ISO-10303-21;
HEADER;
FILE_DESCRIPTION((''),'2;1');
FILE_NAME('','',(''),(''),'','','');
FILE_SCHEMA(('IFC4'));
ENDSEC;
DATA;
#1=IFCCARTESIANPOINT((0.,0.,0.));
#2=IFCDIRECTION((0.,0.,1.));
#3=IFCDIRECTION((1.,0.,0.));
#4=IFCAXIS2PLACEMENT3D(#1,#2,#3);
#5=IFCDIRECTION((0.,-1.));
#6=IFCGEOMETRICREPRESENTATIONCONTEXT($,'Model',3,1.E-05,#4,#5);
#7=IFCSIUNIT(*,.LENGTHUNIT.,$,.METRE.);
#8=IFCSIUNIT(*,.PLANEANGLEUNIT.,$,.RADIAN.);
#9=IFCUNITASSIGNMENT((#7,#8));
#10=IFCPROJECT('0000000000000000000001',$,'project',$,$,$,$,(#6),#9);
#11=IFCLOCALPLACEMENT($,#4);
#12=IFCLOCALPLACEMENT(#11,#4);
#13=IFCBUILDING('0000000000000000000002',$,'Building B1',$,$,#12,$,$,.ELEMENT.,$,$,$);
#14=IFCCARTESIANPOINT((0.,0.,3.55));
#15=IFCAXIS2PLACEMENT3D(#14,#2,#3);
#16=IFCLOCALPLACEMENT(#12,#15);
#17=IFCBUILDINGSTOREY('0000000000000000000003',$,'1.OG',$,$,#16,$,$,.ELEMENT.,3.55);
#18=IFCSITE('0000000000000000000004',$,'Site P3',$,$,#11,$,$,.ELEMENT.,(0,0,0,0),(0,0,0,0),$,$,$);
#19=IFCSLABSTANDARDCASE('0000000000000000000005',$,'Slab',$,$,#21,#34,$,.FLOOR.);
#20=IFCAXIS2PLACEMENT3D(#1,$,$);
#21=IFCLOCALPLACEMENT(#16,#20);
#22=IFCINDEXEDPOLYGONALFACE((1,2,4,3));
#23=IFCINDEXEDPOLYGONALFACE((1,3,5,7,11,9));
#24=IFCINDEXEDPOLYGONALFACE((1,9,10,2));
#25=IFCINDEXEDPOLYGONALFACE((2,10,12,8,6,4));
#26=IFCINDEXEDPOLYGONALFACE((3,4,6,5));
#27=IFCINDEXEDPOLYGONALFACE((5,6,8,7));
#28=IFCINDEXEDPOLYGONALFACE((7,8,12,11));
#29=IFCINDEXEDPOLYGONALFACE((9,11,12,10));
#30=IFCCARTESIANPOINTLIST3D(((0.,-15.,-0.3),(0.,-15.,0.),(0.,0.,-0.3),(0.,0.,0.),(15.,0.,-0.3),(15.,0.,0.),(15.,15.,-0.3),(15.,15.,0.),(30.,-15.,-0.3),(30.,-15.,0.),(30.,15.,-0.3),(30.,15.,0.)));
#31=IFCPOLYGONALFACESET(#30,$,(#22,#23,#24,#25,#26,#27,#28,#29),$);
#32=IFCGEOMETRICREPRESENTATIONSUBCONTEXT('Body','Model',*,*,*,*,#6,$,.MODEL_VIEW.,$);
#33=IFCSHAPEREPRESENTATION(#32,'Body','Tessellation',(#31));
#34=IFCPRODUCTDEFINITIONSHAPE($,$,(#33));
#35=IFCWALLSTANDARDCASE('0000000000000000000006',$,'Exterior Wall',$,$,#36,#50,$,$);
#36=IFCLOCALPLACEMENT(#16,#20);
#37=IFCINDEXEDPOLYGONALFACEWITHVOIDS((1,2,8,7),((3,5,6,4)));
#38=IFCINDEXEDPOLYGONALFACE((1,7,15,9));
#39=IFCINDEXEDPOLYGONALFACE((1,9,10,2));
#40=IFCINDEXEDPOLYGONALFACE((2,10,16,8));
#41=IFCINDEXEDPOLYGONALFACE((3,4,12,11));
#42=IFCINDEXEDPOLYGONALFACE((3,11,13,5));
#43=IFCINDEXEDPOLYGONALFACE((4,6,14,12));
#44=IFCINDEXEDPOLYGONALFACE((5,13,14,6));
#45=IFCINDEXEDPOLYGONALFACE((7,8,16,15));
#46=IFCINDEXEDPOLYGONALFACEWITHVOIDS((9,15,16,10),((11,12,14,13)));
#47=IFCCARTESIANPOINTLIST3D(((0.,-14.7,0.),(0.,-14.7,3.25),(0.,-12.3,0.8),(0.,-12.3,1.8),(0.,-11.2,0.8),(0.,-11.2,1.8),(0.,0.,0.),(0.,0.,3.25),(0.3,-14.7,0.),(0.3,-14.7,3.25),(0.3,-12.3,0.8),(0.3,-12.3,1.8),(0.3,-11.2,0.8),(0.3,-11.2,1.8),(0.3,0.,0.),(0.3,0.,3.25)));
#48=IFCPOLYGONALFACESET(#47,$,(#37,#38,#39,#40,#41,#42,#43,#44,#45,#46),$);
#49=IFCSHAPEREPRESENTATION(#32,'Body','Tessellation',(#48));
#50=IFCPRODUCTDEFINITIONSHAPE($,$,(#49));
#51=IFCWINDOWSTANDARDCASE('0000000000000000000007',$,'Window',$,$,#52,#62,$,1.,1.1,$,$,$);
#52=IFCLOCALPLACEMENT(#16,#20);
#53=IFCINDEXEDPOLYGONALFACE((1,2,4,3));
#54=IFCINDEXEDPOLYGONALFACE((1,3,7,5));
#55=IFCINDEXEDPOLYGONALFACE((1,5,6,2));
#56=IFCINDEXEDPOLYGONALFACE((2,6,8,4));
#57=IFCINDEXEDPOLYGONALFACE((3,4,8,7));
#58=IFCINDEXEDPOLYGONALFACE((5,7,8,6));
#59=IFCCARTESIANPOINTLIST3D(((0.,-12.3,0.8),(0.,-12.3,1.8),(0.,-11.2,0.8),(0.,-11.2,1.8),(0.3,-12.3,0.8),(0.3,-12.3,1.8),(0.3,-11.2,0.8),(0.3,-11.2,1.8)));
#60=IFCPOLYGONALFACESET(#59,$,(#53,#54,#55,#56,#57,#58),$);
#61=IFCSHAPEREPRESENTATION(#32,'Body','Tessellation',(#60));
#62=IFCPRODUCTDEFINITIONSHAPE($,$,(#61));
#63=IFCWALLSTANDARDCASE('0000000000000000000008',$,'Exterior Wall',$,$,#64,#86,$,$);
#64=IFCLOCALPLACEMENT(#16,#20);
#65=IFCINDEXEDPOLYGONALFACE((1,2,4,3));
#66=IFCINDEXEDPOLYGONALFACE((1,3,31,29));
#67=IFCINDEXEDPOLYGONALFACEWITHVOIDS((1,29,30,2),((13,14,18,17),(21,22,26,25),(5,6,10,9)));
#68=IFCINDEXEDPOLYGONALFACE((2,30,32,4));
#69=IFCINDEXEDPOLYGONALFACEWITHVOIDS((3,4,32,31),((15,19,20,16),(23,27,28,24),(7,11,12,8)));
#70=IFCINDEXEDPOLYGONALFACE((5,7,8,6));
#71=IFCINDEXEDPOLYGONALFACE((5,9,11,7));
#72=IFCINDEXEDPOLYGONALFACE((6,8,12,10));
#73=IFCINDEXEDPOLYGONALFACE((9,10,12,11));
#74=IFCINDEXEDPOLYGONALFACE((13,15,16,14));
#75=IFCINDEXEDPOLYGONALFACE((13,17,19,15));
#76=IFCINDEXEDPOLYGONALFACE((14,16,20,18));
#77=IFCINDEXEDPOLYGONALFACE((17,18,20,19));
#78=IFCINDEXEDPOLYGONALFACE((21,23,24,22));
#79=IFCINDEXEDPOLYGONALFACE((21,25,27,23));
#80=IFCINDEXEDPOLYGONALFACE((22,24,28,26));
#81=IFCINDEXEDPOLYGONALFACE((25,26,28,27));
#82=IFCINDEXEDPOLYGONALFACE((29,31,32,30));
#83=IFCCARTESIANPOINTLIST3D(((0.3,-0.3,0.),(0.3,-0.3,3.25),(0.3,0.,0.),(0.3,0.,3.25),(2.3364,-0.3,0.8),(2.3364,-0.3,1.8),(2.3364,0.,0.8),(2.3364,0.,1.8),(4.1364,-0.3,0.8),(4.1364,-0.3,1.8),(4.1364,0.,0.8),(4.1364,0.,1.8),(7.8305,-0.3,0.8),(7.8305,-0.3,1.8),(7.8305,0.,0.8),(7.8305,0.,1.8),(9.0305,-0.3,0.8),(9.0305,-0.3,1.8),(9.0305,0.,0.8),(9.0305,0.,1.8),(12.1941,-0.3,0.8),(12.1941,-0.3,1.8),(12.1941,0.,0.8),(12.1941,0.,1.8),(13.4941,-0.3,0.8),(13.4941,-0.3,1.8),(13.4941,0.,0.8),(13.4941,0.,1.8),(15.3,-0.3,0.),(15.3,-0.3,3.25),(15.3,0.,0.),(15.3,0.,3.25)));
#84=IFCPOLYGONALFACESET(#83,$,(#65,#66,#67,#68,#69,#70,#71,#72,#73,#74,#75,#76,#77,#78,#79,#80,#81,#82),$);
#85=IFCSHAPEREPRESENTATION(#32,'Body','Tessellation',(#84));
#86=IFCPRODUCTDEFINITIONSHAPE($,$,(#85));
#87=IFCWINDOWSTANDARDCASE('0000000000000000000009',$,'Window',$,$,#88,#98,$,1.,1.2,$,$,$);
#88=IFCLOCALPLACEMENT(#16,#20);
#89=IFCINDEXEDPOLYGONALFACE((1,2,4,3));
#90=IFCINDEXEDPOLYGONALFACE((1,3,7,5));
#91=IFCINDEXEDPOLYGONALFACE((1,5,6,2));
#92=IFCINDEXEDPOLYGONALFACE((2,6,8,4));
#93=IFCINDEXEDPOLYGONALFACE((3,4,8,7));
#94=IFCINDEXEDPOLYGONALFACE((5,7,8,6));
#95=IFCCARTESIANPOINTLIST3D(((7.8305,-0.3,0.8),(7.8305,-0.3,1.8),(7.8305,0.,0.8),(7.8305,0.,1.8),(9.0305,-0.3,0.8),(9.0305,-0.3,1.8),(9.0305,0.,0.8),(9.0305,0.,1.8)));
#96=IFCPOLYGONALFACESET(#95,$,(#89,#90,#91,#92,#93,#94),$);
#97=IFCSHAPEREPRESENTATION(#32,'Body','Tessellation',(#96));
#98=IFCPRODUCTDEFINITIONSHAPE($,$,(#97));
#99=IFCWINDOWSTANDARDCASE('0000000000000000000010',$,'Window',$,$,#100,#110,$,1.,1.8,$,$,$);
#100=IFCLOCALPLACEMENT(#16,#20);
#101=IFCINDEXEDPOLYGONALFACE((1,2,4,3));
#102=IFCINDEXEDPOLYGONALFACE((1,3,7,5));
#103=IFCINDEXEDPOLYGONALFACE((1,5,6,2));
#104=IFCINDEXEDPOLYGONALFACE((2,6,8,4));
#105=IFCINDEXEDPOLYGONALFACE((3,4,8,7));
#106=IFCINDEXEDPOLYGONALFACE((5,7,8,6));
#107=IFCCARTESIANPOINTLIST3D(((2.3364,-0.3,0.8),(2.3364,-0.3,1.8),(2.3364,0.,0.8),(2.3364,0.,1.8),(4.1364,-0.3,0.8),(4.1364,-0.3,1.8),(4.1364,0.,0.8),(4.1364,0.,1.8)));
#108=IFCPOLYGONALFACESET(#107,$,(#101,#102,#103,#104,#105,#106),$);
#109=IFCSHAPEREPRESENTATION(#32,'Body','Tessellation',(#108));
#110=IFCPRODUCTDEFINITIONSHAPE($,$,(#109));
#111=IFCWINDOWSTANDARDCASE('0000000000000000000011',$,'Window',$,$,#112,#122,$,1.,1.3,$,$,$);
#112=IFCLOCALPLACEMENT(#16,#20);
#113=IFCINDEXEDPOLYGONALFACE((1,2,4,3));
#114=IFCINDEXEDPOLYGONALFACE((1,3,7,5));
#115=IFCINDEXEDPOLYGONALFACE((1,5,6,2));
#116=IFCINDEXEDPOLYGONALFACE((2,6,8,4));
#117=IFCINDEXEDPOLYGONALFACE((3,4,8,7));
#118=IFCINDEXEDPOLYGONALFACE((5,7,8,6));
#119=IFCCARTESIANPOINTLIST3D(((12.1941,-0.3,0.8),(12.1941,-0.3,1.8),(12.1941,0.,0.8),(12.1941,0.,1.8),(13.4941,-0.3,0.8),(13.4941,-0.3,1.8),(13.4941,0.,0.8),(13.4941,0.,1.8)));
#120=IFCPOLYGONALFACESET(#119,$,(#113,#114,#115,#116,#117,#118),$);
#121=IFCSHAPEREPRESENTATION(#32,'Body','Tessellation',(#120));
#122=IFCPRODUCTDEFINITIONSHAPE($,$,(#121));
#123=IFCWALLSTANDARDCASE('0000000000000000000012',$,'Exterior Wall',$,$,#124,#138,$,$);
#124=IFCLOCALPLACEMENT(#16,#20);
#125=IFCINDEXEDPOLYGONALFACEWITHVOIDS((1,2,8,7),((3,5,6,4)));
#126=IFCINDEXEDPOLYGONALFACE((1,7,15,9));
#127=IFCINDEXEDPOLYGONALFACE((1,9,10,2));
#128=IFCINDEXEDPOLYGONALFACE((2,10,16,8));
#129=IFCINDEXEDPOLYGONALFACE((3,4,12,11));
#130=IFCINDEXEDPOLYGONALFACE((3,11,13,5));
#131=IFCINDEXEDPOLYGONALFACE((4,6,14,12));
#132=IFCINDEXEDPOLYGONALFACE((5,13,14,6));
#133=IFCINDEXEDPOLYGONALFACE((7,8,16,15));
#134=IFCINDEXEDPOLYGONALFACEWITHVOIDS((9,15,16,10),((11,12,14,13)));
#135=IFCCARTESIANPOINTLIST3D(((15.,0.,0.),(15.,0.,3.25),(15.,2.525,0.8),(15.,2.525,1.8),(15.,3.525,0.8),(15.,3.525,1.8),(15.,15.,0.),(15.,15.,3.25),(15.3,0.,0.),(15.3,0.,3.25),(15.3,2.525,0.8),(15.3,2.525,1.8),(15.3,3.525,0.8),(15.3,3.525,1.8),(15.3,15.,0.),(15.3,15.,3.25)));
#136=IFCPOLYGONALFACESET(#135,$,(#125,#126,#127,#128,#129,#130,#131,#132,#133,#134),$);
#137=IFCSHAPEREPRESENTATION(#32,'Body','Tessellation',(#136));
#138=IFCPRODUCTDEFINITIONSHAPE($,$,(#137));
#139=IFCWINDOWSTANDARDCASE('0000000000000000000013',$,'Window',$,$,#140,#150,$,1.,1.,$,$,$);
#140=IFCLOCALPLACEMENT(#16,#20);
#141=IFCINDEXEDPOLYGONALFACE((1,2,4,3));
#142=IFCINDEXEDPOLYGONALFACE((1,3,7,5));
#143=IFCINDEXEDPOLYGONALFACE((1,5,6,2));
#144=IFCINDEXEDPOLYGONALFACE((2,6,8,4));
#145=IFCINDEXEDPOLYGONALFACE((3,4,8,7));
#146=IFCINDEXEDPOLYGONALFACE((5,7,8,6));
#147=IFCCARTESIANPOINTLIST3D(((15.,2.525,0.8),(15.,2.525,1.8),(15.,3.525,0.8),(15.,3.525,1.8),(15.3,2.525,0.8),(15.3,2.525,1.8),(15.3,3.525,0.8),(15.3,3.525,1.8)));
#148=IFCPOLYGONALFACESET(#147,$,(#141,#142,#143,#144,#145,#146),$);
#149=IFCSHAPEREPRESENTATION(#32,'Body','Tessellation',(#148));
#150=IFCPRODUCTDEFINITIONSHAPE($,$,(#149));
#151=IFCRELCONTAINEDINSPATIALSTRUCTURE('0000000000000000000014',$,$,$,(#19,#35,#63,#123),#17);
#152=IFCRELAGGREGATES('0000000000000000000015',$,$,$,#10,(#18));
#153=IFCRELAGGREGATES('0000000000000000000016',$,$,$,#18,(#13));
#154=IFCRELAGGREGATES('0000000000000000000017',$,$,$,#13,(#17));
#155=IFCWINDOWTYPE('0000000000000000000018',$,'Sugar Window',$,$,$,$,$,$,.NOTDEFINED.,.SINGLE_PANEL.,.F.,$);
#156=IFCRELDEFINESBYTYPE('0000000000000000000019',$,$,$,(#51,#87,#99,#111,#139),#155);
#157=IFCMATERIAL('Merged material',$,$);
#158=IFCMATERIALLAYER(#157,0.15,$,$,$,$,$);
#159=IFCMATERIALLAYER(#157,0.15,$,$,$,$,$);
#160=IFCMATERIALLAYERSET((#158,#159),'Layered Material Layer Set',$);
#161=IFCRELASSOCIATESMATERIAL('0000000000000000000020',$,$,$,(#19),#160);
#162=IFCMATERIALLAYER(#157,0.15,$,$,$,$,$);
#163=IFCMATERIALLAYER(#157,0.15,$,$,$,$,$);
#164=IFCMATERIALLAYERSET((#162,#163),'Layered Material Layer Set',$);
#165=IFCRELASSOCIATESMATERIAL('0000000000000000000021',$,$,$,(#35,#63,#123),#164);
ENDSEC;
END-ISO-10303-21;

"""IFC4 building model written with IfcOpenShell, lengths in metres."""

from ifc_helpers import new_model, si_unit, direction, frame, origin_with_axes, place, context, subcontext, project, spatial, polyline, outline, extrude, source, transform, mapped, material, layer, layer_set, layer_usage, type_object, element, fill, save


model = new_model("IFC4")

# Units and contexts
model_context = context("Model", 3, precision=1e-05, world=origin_with_axes(), true_north=direction((0.0, -1.0)))
body_context = subcontext(model_context, "Body", "Model", "MODEL_VIEW")
ifc_project = project(units=[si_unit("LENGTHUNIT", "METRE"), si_unit("PLANEANGLEUNIT", "RADIAN")], contexts=[model_context])

# Site, building, storey
site_placement = place(None, origin_with_axes())
site = spatial("IfcSite", under=ifc_project, at=site_placement, Name="Site P3", CompositionType="ELEMENT", RefLatitude=(0, 0, 0, 0), RefLongitude=(0, 0, 0, 0))
building_placement = place(site_placement, origin_with_axes())
building = spatial("IfcBuilding", under=site, at=building_placement, Name="Building B1", CompositionType="ELEMENT")
storey_placement = place(building_placement, frame((0.0, 0.0, 3.55), z_axis=(0.0, 0.0, 1.0), x_axis=(1.0, 0.0, 0.0)))
storey = spatial("IfcBuildingStorey", under=building, at=storey_placement, Name="1.OG", CompositionType="ELEMENT", Elevation=3.55)

# Slab
ifc_material = material(Name="Merged material")
ifc_layer_1 = layer(ifc_material, 0.15)
ifc_layer_2 = layer(ifc_material, 0.15)
ifc_layer_set_1 = layer_set([ifc_layer_1, ifc_layer_2], Name="Layered Material Layer Set")
ifc_layer_usage_1 = layer_usage(ifc_layer_set_1, "AXIS2", "POSITIVE", -0.15)
slab_placement = place(storey_placement, origin_with_axes())
element("IfcSlabStandardCase", 1, at=slab_placement, inside=storey, material=ifc_layer_usage_1, Name="Slab", PredefinedType="FLOOR", context=body_context, shape_type="SweptSolid", body=[
    extrude(outline(polyline([(0.0, -15.0), (30.0, -15.0), (30.0, 15.0), (15.0, 15.0), (15.0, 0.0), (0.0, 0.0), (0.0, -15.0)])), frame((0.0, 0.0, -0.3), z_axis=(0.0, 0.0, 1.0), x_axis=(1.0, 0.0, 0.0)), (0.0, 0.0, 1.0), 0.3),
])

# Wall, opening, window
ifc_layer_3 = layer(ifc_material, 0.15)
ifc_layer_4 = layer(ifc_material, 0.15)
ifc_layer_set_2 = layer_set([ifc_layer_3, ifc_layer_4], Name="Layered Material Layer Set")
ifc_layer_usage_2 = layer_usage(ifc_layer_set_2, "AXIS2", "POSITIVE", -0.15)
wall_1_placement = place(storey_placement, frame((0.15, 0.0, 0.0), z_axis=(0.0, 0.0, 1.0), x_axis=(0.0, -1.0, 0.0)))
wall_1 = element("IfcWallStandardCase", 2, at=wall_1_placement, inside=storey, material=ifc_layer_usage_2, Name="Exterior Wall", context=body_context, shape_type="SweptSolid", body=[
    extrude(outline(polyline([(0.0, 0.15), (14.7, 0.15), (14.7, -0.15), (0.0, -0.15), (0.0, 0.15)])), origin_with_axes(), (0.0, 0.0, 1.0), 3.25),
])
opening_1_placement = place(wall_1_placement, frame((11.2, 0.0, 0.8), z_axis=(0.0, 0.0, 1.0), x_axis=(1.0, 0.0, 0.0)))
opening_1 = element("IfcOpeningStandardCase", 3, at=opening_1_placement, cuts=wall_1, context=body_context, shape_type="SweptSolid", body=[
    extrude(outline(polyline([(0.0, 0.0), (0.0, 1.1), (1.0, 1.1), (1.0, 0.0), (0.0, 0.0)])), frame((0.0, -0.15, 0.0), z_axis=(0.0, 1.0, 0.0), x_axis=(0.0, 0.0, 1.0)), (0.0, 0.0, 1.0), 0.3),
])
window_type = type_object("IfcWindowType", Name="Sugar Window", ParameterTakesPrecedence=False, PartitioningType="SINGLE_PANEL", PredefinedType="NOTDEFINED")
shared_shape_1 = source(origin_with_axes(), body_context, "Body", "SweptSolid", [
    extrude(outline(polyline([(0.0, 0.0), (0.0, 1.1), (1.0, 1.1), (1.0, 0.0), (0.0, 0.0)])), frame((0.0, -0.15, 0.0), z_axis=(0.0, 1.0, 0.0), x_axis=(0.0, 0.0, 1.0)), (0.0, 0.0, 1.0), 0.3),
])
window_1_placement = place(opening_1_placement, origin_with_axes())
window_1 = element("IfcWindowStandardCase", 4, at=window_1_placement, type_object=window_type, Name="Window", OverallHeight=1.0, OverallWidth=1.1, context=body_context, shape_type="MappedRepresentation", body=[
    mapped(shared_shape_1, transform((0.0, 0.0, 0.0))),
])
fill(opening_1, window_1)

# Wall, openings, windows
wall_2_placement = place(storey_placement, frame((15.3, -0.15, 0.0), z_axis=(0.0, 0.0, 1.0), x_axis=(-1.0, 0.0, 0.0)))
wall_2 = element("IfcWallStandardCase", 5, at=wall_2_placement, inside=storey, material=ifc_layer_usage_2, Name="Exterior Wall", context=body_context, shape_type="SweptSolid", body=[
    extrude(outline(polyline([(0.0, 0.15), (15.0, 0.15), (15.0, -0.15), (0.0, -0.15), (0.0, 0.15)])), origin_with_axes(), (0.0, 0.0, 1.0), 3.25),
])
opening_2_placement = place(wall_2_placement, frame((11.1636, 0.0, 0.8), z_axis=(0.0, 0.0, 1.0), x_axis=(1.0, 0.0, 0.0)))
opening_2 = element("IfcOpeningStandardCase", 6, at=opening_2_placement, cuts=wall_2, context=body_context, shape_type="SweptSolid", body=[
    extrude(outline(polyline([(0.0, 0.0), (0.0, 1.8), (1.0, 1.8), (1.0, 0.0), (0.0, 0.0)])), frame((0.0, -0.15, 0.0), z_axis=(0.0, 1.0, 0.0), x_axis=(0.0, 0.0, 1.0)), (0.0, 0.0, 1.0), 0.3),
])
opening_3_placement = place(wall_2_placement, frame((6.2695, 0.0, 0.8), z_axis=(0.0, 0.0, 1.0), x_axis=(1.0, 0.0, 0.0)))
opening_3 = element("IfcOpeningStandardCase", 7, at=opening_3_placement, cuts=wall_2, context=body_context, shape_type="SweptSolid", body=[
    extrude(outline(polyline([(0.0, 0.0), (0.0, 1.2), (1.0, 1.2), (1.0, 0.0), (0.0, 0.0)])), frame((0.0, -0.15, 0.0), z_axis=(0.0, 1.0, 0.0), x_axis=(0.0, 0.0, 1.0)), (0.0, 0.0, 1.0), 0.3),
])
opening_4_placement = place(wall_2_placement, frame((1.8059, 0.0, 0.8), z_axis=(0.0, 0.0, 1.0), x_axis=(1.0, 0.0, 0.0)))
opening_4 = element("IfcOpeningStandardCase", 8, at=opening_4_placement, cuts=wall_2, context=body_context, shape_type="SweptSolid", body=[
    extrude(outline(polyline([(0.0, 0.0), (0.0, 1.3), (1.0, 1.3), (1.0, 0.0), (0.0, 0.0)])), frame((0.0, -0.15, 0.0), z_axis=(0.0, 1.0, 0.0), x_axis=(0.0, 0.0, 1.0)), (0.0, 0.0, 1.0), 0.3),
])
shared_shape_2 = source(origin_with_axes(), body_context, "Body", "SweptSolid", [
    extrude(outline(polyline([(0.0, 0.0), (0.0, 1.2), (1.0, 1.2), (1.0, 0.0), (0.0, 0.0)])), frame((0.0, -0.15, 0.0), z_axis=(0.0, 1.0, 0.0), x_axis=(0.0, 0.0, 1.0)), (0.0, 0.0, 1.0), 0.3),
])
window_2_placement = place(opening_3_placement, origin_with_axes())
window_2 = element("IfcWindowStandardCase", 9, at=window_2_placement, type_object=window_type, Name="Window", OverallHeight=1.0, OverallWidth=1.2, context=body_context, shape_type="MappedRepresentation", body=[
    mapped(shared_shape_2, transform((0.0, 0.0, 0.0))),
])
fill(opening_3, window_2)
shared_shape_3 = source(origin_with_axes(), body_context, "Body", "SweptSolid", [
    extrude(outline(polyline([(0.0, 0.0), (0.0, 1.8), (1.0, 1.8), (1.0, 0.0), (0.0, 0.0)])), frame((0.0, -0.15, 0.0), z_axis=(0.0, 1.0, 0.0), x_axis=(0.0, 0.0, 1.0)), (0.0, 0.0, 1.0), 0.3),
])
window_3_placement = place(opening_2_placement, origin_with_axes())
window_3 = element("IfcWindowStandardCase", 10, at=window_3_placement, type_object=window_type, Name="Window", OverallHeight=1.0, OverallWidth=1.8, context=body_context, shape_type="MappedRepresentation", body=[
    mapped(shared_shape_3, transform((0.0, 0.0, 0.0))),
])
fill(opening_2, window_3)
shared_shape_4 = source(origin_with_axes(), body_context, "Body", "SweptSolid", [
    extrude(outline(polyline([(0.0, 0.0), (0.0, 1.3), (1.0, 1.3), (1.0, 0.0), (0.0, 0.0)])), frame((0.0, -0.15, 0.0), z_axis=(0.0, 1.0, 0.0), x_axis=(0.0, 0.0, 1.0)), (0.0, 0.0, 1.0), 0.3),
])
window_4_placement = place(opening_4_placement, origin_with_axes())
window_4 = element("IfcWindowStandardCase", 11, at=window_4_placement, type_object=window_type, Name="Window", OverallHeight=1.0, OverallWidth=1.3, context=body_context, shape_type="MappedRepresentation", body=[
    mapped(shared_shape_4, transform((0.0, 0.0, 0.0))),
])
fill(opening_4, window_4)

# Wall, opening, window
wall_3_placement = place(storey_placement, frame((15.15, 15.0, 0.0), z_axis=(0.0, 0.0, 1.0), x_axis=(0.0, -1.0, 0.0)))
wall_3 = element("IfcWallStandardCase", 12, at=wall_3_placement, inside=storey, material=ifc_layer_usage_2, Name="Exterior Wall", context=body_context, shape_type="SweptSolid", body=[
    extrude(outline(polyline([(0.0, 0.15), (15.0, 0.15), (15.0, -0.15), (0.0, -0.15), (0.0, 0.15)])), origin_with_axes(), (0.0, 0.0, 1.0), 3.25),
])
opening_5_placement = place(wall_3_placement, frame((11.475, 0.0, 0.8), z_axis=(0.0, 0.0, 1.0), x_axis=(1.0, 0.0, 0.0)))
opening_5 = element("IfcOpeningStandardCase", 13, at=opening_5_placement, cuts=wall_3, context=body_context, shape_type="SweptSolid", body=[
    extrude(outline(polyline([(0.0, 0.0), (0.0, 1.0), (1.0, 1.0), (1.0, 0.0), (0.0, 0.0)])), frame((0.0, -0.15, 0.0), z_axis=(0.0, 1.0, 0.0), x_axis=(0.0, 0.0, 1.0)), (0.0, 0.0, 1.0), 0.3),
])
shared_shape_5 = source(origin_with_axes(), body_context, "Body", "SweptSolid", [
    extrude(outline(polyline([(0.0, 0.0), (0.0, 1.0), (1.0, 1.0), (1.0, 0.0), (0.0, 0.0)])), frame((0.0, -0.15, 0.0), z_axis=(0.0, 1.0, 0.0), x_axis=(0.0, 0.0, 1.0)), (0.0, 0.0, 1.0), 0.3),
])
window_5_placement = place(opening_5_placement, origin_with_axes())
window_5 = element("IfcWindowStandardCase", 14, at=window_5_placement, type_object=window_type, Name="Window", OverallHeight=1.0, OverallWidth=1.0, context=body_context, shape_type="MappedRepresentation", body=[
    mapped(shared_shape_5, transform((0.0, 0.0, 0.0))),
])
fill(opening_5, window_5)

save(model, "model.ifc")
